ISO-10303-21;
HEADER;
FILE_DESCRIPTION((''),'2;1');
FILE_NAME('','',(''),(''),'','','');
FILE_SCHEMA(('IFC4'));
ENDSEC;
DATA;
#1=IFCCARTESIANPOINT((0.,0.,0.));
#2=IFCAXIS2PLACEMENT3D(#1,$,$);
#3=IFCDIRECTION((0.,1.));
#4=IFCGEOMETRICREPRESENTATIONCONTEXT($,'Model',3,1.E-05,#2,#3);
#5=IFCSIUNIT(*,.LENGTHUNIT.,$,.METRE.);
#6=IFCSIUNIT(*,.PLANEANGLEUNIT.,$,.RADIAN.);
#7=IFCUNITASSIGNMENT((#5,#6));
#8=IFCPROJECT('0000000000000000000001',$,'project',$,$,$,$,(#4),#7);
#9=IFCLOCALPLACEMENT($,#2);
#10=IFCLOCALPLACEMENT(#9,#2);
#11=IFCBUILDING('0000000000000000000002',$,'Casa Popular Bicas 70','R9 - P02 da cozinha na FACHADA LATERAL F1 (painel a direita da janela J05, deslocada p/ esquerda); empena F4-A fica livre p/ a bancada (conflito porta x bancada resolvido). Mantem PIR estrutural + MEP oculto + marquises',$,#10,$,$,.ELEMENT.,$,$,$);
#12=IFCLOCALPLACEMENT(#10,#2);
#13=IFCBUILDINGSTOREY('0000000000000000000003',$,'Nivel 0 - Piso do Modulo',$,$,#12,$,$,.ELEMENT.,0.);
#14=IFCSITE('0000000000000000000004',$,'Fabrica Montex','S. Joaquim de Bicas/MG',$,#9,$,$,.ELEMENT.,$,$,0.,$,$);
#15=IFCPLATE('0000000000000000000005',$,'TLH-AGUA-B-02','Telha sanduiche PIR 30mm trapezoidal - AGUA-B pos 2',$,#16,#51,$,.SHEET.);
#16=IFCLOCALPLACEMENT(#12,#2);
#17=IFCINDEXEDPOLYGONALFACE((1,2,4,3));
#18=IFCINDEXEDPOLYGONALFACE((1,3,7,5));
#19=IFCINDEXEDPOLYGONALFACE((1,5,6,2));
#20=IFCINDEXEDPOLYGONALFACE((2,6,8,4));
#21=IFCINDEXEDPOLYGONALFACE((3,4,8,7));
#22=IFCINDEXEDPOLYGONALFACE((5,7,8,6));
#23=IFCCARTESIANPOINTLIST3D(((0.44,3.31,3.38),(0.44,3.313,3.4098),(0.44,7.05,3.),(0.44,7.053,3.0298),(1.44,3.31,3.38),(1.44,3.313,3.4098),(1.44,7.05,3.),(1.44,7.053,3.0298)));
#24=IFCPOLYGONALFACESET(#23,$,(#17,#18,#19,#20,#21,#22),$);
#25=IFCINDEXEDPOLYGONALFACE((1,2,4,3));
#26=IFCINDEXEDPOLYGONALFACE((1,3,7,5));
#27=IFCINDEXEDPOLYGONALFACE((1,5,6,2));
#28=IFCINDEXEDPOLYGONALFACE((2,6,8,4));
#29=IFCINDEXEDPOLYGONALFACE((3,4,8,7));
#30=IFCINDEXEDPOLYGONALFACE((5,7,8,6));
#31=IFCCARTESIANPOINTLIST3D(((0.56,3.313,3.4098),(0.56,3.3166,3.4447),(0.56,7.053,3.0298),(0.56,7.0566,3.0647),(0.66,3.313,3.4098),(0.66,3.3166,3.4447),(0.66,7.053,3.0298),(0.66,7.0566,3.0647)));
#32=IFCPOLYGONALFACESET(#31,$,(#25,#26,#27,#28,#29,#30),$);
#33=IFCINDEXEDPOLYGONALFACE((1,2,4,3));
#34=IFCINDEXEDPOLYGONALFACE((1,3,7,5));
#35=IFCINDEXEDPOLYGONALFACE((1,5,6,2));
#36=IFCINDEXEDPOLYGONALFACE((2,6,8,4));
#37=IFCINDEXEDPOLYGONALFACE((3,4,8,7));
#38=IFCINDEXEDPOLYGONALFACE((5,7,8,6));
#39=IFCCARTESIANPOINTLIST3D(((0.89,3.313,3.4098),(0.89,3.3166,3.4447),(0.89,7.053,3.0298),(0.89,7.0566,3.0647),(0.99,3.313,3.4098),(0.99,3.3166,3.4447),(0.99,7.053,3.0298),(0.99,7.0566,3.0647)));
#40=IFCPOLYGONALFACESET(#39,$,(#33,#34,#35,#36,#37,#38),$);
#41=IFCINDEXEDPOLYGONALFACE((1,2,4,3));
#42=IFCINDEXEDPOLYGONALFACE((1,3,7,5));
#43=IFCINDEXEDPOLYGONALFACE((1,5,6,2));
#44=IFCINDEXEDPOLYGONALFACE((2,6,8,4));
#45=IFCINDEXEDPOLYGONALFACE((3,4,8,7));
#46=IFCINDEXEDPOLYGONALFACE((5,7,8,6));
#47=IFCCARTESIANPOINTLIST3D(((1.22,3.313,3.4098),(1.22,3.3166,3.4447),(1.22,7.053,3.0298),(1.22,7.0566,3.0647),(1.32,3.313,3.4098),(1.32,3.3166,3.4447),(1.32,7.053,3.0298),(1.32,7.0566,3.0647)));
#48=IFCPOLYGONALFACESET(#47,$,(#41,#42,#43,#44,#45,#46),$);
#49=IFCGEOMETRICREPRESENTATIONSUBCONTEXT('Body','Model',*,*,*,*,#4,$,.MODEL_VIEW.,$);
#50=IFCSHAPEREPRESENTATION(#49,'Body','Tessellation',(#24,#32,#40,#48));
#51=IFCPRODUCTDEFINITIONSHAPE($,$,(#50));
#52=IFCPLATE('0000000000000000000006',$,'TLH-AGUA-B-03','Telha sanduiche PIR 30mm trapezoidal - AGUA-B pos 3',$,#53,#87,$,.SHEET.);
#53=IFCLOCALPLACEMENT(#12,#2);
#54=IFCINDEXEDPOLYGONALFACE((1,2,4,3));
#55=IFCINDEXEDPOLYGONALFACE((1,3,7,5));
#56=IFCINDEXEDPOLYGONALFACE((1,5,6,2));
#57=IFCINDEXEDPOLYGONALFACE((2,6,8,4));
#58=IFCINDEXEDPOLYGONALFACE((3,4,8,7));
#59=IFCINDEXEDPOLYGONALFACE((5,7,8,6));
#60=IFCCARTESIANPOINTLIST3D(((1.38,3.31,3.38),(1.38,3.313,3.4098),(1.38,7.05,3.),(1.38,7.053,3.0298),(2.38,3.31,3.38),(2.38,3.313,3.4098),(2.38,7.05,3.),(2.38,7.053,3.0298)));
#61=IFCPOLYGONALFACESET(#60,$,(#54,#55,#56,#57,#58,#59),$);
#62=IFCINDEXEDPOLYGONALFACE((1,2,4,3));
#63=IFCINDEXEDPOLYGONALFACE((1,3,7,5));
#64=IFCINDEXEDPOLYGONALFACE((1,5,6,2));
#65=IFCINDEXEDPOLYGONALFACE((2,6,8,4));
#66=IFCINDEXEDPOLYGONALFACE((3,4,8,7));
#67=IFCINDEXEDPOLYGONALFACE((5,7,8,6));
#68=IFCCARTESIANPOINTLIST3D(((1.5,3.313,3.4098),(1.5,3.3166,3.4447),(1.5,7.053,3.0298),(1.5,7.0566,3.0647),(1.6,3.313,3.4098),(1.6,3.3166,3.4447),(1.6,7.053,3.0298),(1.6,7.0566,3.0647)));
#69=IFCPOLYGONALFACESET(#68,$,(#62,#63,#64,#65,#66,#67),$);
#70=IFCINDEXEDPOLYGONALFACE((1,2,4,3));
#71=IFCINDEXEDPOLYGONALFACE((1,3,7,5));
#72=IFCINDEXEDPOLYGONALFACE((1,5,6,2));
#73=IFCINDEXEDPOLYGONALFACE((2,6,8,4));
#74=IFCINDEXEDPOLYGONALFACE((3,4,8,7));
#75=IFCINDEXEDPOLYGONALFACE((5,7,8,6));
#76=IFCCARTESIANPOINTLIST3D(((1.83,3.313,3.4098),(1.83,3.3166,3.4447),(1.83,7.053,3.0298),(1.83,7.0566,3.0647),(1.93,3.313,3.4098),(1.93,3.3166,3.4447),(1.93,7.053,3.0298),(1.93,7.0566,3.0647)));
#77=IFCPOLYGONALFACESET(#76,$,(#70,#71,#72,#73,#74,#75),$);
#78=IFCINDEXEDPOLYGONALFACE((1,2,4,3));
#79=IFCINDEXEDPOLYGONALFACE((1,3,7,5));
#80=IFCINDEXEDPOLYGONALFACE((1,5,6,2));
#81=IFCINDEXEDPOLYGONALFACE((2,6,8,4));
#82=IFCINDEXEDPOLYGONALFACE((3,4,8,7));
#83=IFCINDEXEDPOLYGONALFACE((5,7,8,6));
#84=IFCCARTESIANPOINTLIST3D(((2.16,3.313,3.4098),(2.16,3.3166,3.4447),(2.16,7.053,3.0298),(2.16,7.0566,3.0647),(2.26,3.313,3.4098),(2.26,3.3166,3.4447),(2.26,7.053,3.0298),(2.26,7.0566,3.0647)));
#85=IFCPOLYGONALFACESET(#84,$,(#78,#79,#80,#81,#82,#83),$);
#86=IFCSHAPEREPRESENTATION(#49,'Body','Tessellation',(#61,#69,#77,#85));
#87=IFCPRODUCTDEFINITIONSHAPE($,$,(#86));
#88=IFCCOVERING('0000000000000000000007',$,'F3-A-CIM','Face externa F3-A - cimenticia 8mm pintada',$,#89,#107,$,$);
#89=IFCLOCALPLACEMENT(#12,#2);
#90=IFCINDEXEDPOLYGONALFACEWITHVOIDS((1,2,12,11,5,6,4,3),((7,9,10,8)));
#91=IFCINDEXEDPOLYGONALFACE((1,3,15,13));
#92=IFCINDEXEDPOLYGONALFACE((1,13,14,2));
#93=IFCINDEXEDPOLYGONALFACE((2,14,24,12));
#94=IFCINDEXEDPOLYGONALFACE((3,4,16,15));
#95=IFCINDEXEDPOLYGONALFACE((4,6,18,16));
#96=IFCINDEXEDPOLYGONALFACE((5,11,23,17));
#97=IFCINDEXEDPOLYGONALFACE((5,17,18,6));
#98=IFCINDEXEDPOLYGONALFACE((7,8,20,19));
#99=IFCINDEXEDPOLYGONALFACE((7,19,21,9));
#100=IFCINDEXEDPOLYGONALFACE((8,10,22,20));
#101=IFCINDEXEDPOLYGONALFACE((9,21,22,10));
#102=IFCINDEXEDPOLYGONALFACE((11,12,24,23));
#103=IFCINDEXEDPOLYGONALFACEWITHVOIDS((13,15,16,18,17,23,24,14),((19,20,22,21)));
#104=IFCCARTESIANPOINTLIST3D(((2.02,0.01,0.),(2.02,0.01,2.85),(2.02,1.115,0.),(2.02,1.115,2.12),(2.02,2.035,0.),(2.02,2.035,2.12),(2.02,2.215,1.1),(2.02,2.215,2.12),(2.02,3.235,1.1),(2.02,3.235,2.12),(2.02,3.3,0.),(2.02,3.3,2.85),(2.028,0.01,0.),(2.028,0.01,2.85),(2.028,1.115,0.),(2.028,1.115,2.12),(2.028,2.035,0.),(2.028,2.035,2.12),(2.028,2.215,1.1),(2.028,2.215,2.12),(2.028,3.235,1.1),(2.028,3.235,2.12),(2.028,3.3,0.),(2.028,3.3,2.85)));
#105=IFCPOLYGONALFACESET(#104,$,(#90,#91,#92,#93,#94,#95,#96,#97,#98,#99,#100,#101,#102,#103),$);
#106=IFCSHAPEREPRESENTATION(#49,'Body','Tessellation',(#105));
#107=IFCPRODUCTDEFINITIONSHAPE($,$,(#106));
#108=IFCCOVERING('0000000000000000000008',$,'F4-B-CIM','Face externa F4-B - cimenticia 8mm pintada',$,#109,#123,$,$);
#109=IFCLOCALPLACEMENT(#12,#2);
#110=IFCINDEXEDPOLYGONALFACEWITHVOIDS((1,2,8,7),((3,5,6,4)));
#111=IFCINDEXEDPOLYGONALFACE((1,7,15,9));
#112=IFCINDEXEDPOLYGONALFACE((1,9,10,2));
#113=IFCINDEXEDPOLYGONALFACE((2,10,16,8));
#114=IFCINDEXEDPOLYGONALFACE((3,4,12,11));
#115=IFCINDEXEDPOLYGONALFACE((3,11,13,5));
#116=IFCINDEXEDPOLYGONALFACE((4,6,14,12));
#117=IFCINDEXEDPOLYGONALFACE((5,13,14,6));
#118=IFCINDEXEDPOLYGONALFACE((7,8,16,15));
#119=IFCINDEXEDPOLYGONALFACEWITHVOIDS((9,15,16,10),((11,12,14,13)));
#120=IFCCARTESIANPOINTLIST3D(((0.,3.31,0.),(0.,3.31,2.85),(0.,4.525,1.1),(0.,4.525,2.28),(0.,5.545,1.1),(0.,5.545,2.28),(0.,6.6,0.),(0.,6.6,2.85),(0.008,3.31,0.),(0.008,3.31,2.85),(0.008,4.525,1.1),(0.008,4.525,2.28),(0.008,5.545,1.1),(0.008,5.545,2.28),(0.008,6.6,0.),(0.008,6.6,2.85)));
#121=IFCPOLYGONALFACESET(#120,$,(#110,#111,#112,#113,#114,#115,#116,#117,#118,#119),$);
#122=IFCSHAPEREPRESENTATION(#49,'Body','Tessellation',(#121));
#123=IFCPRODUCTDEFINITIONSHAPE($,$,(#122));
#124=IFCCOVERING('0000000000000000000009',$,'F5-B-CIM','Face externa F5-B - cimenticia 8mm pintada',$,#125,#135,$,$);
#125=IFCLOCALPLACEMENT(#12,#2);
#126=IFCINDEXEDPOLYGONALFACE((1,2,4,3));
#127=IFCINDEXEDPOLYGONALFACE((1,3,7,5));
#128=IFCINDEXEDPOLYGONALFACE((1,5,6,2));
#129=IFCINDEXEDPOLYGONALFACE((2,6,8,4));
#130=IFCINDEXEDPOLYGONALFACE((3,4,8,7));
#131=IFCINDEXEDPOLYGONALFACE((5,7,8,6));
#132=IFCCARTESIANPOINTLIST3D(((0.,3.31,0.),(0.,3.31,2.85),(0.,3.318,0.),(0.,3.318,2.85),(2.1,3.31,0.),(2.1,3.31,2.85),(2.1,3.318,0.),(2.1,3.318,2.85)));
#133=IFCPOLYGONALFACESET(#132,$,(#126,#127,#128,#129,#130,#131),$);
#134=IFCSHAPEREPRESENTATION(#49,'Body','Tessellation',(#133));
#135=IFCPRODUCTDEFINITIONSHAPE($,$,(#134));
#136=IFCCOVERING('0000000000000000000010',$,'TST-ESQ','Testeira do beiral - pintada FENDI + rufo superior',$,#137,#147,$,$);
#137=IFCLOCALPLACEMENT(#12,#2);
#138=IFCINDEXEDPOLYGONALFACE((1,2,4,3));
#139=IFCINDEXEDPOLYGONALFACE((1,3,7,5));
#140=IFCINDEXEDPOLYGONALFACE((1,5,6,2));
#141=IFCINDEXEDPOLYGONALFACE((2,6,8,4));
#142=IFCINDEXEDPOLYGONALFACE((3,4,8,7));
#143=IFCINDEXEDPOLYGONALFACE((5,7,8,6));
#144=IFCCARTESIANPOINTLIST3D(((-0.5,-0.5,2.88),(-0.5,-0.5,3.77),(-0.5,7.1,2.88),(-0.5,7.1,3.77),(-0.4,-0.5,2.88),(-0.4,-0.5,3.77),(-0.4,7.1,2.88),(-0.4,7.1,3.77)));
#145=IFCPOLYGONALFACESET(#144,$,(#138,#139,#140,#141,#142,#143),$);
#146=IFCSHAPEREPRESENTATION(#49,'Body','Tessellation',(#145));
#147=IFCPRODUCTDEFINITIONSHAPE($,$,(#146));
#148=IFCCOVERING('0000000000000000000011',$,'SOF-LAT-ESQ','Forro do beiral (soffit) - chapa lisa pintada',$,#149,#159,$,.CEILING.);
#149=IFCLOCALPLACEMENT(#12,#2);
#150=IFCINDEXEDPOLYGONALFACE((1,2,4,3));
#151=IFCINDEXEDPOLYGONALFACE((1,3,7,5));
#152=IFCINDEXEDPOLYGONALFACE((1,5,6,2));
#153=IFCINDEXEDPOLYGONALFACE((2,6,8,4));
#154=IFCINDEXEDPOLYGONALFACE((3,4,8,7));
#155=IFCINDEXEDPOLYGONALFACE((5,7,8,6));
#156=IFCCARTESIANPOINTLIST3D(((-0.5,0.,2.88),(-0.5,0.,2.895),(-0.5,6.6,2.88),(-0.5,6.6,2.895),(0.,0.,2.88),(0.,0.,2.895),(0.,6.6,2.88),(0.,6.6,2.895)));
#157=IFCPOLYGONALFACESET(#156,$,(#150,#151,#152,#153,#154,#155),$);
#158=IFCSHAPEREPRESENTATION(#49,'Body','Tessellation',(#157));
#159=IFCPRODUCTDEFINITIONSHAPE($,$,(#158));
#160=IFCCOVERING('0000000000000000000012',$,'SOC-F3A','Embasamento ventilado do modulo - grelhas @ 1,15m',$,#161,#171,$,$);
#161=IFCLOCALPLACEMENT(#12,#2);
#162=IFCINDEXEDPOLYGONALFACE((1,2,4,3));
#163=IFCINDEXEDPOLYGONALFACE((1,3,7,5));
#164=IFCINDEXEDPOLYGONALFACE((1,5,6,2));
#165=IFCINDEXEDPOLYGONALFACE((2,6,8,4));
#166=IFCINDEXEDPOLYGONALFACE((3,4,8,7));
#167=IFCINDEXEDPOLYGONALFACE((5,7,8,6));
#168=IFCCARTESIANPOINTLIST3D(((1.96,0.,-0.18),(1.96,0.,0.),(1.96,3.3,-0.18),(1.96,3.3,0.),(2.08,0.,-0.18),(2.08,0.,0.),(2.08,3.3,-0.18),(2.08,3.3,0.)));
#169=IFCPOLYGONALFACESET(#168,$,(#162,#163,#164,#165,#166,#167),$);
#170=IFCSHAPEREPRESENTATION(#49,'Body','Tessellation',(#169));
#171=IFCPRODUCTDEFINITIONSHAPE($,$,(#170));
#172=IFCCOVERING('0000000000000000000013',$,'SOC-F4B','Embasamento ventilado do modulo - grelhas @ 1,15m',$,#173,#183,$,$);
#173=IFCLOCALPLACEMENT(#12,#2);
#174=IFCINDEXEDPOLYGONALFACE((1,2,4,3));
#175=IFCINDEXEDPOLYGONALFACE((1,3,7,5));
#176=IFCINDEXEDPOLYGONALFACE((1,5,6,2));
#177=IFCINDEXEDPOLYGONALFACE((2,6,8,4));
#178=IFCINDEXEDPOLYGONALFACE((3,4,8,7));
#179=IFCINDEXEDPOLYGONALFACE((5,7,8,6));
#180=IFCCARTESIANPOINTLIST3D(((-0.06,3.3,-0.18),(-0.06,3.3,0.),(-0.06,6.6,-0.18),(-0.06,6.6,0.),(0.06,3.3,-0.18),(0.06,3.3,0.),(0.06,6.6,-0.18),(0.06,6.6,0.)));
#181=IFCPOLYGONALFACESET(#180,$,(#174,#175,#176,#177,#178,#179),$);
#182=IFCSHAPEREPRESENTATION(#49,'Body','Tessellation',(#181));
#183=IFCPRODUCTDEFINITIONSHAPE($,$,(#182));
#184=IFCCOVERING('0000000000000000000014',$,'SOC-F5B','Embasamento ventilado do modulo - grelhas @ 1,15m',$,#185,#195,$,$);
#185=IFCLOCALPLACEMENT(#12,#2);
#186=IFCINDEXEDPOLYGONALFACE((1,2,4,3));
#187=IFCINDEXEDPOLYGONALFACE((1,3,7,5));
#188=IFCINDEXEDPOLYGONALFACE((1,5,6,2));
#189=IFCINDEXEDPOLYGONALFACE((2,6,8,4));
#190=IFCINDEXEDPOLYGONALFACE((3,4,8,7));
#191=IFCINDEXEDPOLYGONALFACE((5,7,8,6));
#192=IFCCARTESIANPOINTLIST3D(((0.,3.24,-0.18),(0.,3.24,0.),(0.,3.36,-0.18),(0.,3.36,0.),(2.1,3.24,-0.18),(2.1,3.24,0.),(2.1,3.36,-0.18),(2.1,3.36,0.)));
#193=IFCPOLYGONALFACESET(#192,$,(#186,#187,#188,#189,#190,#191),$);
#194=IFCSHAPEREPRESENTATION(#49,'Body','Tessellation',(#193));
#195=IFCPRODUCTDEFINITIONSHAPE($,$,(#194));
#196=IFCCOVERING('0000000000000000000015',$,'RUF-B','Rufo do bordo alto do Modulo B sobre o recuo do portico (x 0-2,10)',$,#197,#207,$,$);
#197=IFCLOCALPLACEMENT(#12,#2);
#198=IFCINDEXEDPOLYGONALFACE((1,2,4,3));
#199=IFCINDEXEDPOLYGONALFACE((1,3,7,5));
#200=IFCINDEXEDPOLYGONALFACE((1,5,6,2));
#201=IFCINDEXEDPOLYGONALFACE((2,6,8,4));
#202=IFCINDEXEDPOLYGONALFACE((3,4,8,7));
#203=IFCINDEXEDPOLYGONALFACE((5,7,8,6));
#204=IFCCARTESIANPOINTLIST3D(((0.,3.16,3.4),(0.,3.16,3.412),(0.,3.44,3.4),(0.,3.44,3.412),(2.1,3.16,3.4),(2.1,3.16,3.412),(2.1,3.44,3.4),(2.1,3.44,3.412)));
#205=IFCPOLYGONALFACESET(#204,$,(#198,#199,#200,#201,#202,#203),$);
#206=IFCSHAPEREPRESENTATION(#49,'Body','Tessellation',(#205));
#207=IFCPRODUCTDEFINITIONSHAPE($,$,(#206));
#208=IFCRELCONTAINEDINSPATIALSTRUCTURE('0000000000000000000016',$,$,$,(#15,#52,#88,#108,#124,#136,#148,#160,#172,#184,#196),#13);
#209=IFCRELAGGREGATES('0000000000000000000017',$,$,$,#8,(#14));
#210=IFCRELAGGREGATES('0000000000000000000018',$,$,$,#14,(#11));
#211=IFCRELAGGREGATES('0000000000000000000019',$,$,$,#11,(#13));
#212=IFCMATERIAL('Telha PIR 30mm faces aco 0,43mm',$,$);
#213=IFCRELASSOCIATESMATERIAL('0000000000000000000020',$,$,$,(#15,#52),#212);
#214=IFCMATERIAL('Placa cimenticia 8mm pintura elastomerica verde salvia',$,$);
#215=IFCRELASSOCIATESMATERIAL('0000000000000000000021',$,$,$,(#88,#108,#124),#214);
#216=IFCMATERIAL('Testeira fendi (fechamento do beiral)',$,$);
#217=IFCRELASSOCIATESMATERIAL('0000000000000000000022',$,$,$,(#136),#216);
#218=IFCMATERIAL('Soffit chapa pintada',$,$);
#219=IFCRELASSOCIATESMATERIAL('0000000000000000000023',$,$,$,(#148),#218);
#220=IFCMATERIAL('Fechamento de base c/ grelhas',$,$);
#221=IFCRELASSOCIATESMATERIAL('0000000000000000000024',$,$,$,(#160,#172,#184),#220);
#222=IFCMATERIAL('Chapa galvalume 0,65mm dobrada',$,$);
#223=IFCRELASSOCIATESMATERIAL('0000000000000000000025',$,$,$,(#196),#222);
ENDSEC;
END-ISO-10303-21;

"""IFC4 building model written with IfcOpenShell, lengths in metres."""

from ifc_helpers import new_model, si_unit, direction, frame, frame_2d, origin, place, context, subcontext, project, spatial, rectangle, extrude, material, element, save


model = new_model("IFC4")

# Units and contexts
model_context = context("Model", 3, precision=1e-05, world=origin(), true_north=direction((0.0, 1.0)))
body_context = subcontext(model_context, "Body", "Model", "MODEL_VIEW")
ifc_project = project(units=[si_unit("LENGTHUNIT", "METRE"), si_unit("PLANEANGLEUNIT", "RADIAN")], contexts=[model_context])

# Site, building, storey
site_placement = place(None, origin())
site = spatial("IfcSite", under=ifc_project, at=site_placement, Name="Fabrica Montex", Description="S. Joaquim de Bicas/MG", CompositionType="ELEMENT", RefElevation=0.0)
building_placement = place(site_placement, origin())
building = spatial("IfcBuilding", under=site, at=building_placement, Name="Casa Popular Bicas 70", Description="R9 - P02 da cozinha na FACHADA LATERAL F1 (painel a direita da janela J05, deslocada p/ esquerda); empena F4-A fica livre p/ a bancada (conflito porta x bancada resolvido). Mantem PIR estrutural + MEP oculto + marquises", CompositionType="ELEMENT")
storey_placement = place(building_placement, origin())
storey = spatial("IfcBuildingStorey", under=building, at=storey_placement, Name="Nivel 0 - Piso do Modulo", CompositionType="ELEMENT", Elevation=0.0)

# Plates
ifc_material_1 = material(Name="Telha PIR 30mm faces aco 0,43mm")
for number, where, z_axis, x_axis, name, description in (
    (1, (0.44, 3.31, 3.38), (0.0, 0.101084, 0.994878), (1.0, 0.0, 0.0), "TLH-AGUA-B-02", "Telha sanduiche PIR 30mm trapezoidal - AGUA-B pos 2"),
    (2, (1.38, 3.31, 3.38), (0.0, 0.101084, 0.994878), (1.0, 0.0, 0.0), "TLH-AGUA-B-03", "Telha sanduiche PIR 30mm trapezoidal - AGUA-B pos 3"),
):
    element("IfcPlate", number, at=place(storey_placement, frame(where, z_axis=z_axis, x_axis=x_axis)), inside=storey, material=ifc_material_1, Name=name, Description=description, PredefinedType="SHEET", context=body_context, shape_type="SweptSolid", body=[
        extrude(rectangle(XDim=1.0, YDim=3.7593, at=frame_2d((0.5, 1.8796))), origin(), (0.0, 0.0, 1.0), 0.03),
        extrude(rectangle(XDim=0.1, YDim=3.7593, at=frame_2d((0.17, 1.8796))), frame((0.0, 0.0, 0.03)), (0.0, 0.0, 1.0), 0.035),
        extrude(rectangle(XDim=0.1, YDim=3.7593, at=frame_2d((0.5, 1.8796))), frame((0.0, 0.0, 0.03)), (0.0, 0.0, 1.0), 0.035),
        extrude(rectangle(XDim=0.1, YDim=3.7593, at=frame_2d((0.83, 1.8796))), frame((0.0, 0.0, 0.03)), (0.0, 0.0, 1.0), 0.035),
    ])

# Covering, openings
ifc_material_2 = material(Name="Placa cimenticia 8mm pintura elastomerica verde salvia")
covering_1_placement = place(None, frame((2.024, 3.3, 0.0), z_axis=(0.0, 0.0, 1.0), x_axis=(0.0, -1.0, 0.0)))
covering_1 = element("IfcCovering", 3, at=covering_1_placement, inside=storey, material=ifc_material_2, Name="F3-A-CIM", Description="Face externa F3-A - cimenticia 8mm pintada", context=body_context, shape_type="SweptSolid", body=[
    extrude(rectangle(XDim=3.29, YDim=0.008, at=frame_2d((1.645, 0.0))), origin(), (0.0, 0.0, 1.0), 2.85),
])
opening_1_placement = place(None, frame((2.024, 3.225, 1.1), z_axis=(0.0, 0.0, 1.0), x_axis=(0.0, -1.0, 0.0)))
element("IfcOpeningElement", 4, at=opening_1_placement, cuts=covering_1, PredefinedType="OPENING", context=body_context, shape_type="SweptSolid", body=[
    extrude(rectangle(XDim=1.02, YDim=0.03, at=frame_2d((0.5, 0.0))), origin(), (0.0, 0.0, 1.0), 1.02),
])
opening_2_placement = place(None, frame((2.024, 2.025, 0.0), z_axis=(0.0, 0.0, 1.0), x_axis=(0.0, -1.0, 0.0)))
element("IfcOpeningElement", 5, at=opening_2_placement, cuts=covering_1, PredefinedType="OPENING", context=body_context, shape_type="SweptSolid", body=[
    extrude(rectangle(XDim=0.92, YDim=0.03, at=frame_2d((0.45, 0.0))), origin(), (0.0, 0.0, 1.0), 2.12),
])

# Covering, opening
covering_2_placement = place(storey_placement, frame((0.004, 3.31, 0.0), x_axis=(0.0, 1.0, 0.0)))
covering_2 = element("IfcCovering", 6, at=covering_2_placement, inside=storey, material=ifc_material_2, Name="F4-B-CIM", Description="Face externa F4-B - cimenticia 8mm pintada", context=body_context, shape_type="SweptSolid", body=[
    extrude(rectangle(XDim=3.29, YDim=0.008, at=frame_2d((1.645, 0.0))), origin(), (0.0, 0.0, 1.0), 2.85),
])
opening_3_placement = place(storey_placement, frame((0.004, 4.535, 1.1), x_axis=(0.0, 1.0, 0.0)))
element("IfcOpeningElement", 7, at=opening_3_placement, cuts=covering_2, PredefinedType="OPENING", context=body_context, shape_type="SweptSolid", body=[
    extrude(rectangle(XDim=1.02, YDim=0.03, at=frame_2d((0.5, 0.0))), origin(), (0.0, 0.0, 1.0), 1.18),
])

# Coverings
covering_3_placement = place(storey_placement, frame((0.0, 3.314, 0.0), x_axis=(1.0, 0.0, 0.0)))
element("IfcCovering", 8, at=covering_3_placement, inside=storey, material=ifc_material_2, Name="F5-B-CIM", Description="Face externa F5-B - cimenticia 8mm pintada", context=body_context, shape_type="SweptSolid", body=[
    extrude(rectangle(XDim=2.1, YDim=0.008, at=frame_2d((1.05, 0.0))), origin(), (0.0, 0.0, 1.0), 2.85),
])
ifc_material_3 = material(Name="Testeira fendi (fechamento do beiral)")
covering_4_placement = place(storey_placement, frame((-0.45, -0.5, 2.88), x_axis=(0.0, 1.0, 0.0)))
element("IfcCovering", 9, at=covering_4_placement, inside=storey, material=ifc_material_3, Name="TST-ESQ", Description="Testeira do beiral - pintada FENDI + rufo superior", context=body_context, shape_type="SweptSolid", body=[
    extrude(rectangle(XDim=7.6, YDim=0.1, at=frame_2d((3.8, 0.0))), origin(), (0.0, 0.0, 1.0), 0.89),
])
ifc_material_4 = material(Name="Soffit chapa pintada")
covering_5_placement = place(storey_placement, frame((-0.5, 0.0, 2.88)))
element("IfcCovering", 10, at=covering_5_placement, inside=storey, material=ifc_material_4, Name="SOF-LAT-ESQ", Description="Forro do beiral (soffit) - chapa lisa pintada", PredefinedType="CEILING", context=body_context, shape_type="SweptSolid", body=[
    extrude(rectangle(XDim=0.5, YDim=6.6, at=frame_2d((0.25, 3.3))), origin(), (0.0, 0.0, 1.0), 0.015),
])
ifc_material_5 = material(Name="Fechamento de base c/ grelhas")
covering_6_placement = place(None, frame((2.02, 3.3, -0.18), z_axis=(0.0, 0.0, 1.0), x_axis=(0.0, -1.0, 0.0)))
element("IfcCovering", 11, at=covering_6_placement, inside=storey, material=ifc_material_5, Name="SOC-F3A", Description="Embasamento ventilado do modulo - grelhas @ 1,15m", context=body_context, shape_type="SweptSolid", body=[
    extrude(rectangle(XDim=3.3, YDim=0.12, at=frame_2d((1.65, 0.0))), origin(), (0.0, 0.0, 1.0), 0.18),
])
covering_7_placement = place(storey_placement, frame((0.0, 3.3, -0.18), x_axis=(0.0, 1.0, 0.0)))
element("IfcCovering", 12, at=covering_7_placement, inside=storey, material=ifc_material_5, Name="SOC-F4B", Description="Embasamento ventilado do modulo - grelhas @ 1,15m", context=body_context, shape_type="SweptSolid", body=[
    extrude(rectangle(XDim=3.3, YDim=0.12, at=frame_2d((1.65, 0.0))), origin(), (0.0, 0.0, 1.0), 0.18),
])
covering_8_placement = place(storey_placement, frame((0.0, 3.3, -0.18), x_axis=(1.0, 0.0, 0.0)))
element("IfcCovering", 13, at=covering_8_placement, inside=storey, material=ifc_material_5, Name="SOC-F5B", Description="Embasamento ventilado do modulo - grelhas @ 1,15m", context=body_context, shape_type="SweptSolid", body=[
    extrude(rectangle(XDim=2.1, YDim=0.12, at=frame_2d((1.05, 0.0))), origin(), (0.0, 0.0, 1.0), 0.18),
])
ifc_material_6 = material(Name="Chapa galvalume 0,65mm dobrada")
covering_9_placement = place(storey_placement, frame((0.0, 3.16, 3.4), x_axis=(1.0, 0.0, 0.0)))
element("IfcCovering", 14, at=covering_9_placement, inside=storey, material=ifc_material_6, Name="RUF-B", Description="Rufo do bordo alto do Modulo B sobre o recuo do portico (x 0-2,10)", context=body_context, shape_type="SweptSolid", body=[
    extrude(rectangle(XDim=2.1, YDim=0.28, at=frame_2d((1.05, 0.14))), origin(), (0.0, 0.0, 1.0), 0.012),
])

save(model, "model.ifc")
